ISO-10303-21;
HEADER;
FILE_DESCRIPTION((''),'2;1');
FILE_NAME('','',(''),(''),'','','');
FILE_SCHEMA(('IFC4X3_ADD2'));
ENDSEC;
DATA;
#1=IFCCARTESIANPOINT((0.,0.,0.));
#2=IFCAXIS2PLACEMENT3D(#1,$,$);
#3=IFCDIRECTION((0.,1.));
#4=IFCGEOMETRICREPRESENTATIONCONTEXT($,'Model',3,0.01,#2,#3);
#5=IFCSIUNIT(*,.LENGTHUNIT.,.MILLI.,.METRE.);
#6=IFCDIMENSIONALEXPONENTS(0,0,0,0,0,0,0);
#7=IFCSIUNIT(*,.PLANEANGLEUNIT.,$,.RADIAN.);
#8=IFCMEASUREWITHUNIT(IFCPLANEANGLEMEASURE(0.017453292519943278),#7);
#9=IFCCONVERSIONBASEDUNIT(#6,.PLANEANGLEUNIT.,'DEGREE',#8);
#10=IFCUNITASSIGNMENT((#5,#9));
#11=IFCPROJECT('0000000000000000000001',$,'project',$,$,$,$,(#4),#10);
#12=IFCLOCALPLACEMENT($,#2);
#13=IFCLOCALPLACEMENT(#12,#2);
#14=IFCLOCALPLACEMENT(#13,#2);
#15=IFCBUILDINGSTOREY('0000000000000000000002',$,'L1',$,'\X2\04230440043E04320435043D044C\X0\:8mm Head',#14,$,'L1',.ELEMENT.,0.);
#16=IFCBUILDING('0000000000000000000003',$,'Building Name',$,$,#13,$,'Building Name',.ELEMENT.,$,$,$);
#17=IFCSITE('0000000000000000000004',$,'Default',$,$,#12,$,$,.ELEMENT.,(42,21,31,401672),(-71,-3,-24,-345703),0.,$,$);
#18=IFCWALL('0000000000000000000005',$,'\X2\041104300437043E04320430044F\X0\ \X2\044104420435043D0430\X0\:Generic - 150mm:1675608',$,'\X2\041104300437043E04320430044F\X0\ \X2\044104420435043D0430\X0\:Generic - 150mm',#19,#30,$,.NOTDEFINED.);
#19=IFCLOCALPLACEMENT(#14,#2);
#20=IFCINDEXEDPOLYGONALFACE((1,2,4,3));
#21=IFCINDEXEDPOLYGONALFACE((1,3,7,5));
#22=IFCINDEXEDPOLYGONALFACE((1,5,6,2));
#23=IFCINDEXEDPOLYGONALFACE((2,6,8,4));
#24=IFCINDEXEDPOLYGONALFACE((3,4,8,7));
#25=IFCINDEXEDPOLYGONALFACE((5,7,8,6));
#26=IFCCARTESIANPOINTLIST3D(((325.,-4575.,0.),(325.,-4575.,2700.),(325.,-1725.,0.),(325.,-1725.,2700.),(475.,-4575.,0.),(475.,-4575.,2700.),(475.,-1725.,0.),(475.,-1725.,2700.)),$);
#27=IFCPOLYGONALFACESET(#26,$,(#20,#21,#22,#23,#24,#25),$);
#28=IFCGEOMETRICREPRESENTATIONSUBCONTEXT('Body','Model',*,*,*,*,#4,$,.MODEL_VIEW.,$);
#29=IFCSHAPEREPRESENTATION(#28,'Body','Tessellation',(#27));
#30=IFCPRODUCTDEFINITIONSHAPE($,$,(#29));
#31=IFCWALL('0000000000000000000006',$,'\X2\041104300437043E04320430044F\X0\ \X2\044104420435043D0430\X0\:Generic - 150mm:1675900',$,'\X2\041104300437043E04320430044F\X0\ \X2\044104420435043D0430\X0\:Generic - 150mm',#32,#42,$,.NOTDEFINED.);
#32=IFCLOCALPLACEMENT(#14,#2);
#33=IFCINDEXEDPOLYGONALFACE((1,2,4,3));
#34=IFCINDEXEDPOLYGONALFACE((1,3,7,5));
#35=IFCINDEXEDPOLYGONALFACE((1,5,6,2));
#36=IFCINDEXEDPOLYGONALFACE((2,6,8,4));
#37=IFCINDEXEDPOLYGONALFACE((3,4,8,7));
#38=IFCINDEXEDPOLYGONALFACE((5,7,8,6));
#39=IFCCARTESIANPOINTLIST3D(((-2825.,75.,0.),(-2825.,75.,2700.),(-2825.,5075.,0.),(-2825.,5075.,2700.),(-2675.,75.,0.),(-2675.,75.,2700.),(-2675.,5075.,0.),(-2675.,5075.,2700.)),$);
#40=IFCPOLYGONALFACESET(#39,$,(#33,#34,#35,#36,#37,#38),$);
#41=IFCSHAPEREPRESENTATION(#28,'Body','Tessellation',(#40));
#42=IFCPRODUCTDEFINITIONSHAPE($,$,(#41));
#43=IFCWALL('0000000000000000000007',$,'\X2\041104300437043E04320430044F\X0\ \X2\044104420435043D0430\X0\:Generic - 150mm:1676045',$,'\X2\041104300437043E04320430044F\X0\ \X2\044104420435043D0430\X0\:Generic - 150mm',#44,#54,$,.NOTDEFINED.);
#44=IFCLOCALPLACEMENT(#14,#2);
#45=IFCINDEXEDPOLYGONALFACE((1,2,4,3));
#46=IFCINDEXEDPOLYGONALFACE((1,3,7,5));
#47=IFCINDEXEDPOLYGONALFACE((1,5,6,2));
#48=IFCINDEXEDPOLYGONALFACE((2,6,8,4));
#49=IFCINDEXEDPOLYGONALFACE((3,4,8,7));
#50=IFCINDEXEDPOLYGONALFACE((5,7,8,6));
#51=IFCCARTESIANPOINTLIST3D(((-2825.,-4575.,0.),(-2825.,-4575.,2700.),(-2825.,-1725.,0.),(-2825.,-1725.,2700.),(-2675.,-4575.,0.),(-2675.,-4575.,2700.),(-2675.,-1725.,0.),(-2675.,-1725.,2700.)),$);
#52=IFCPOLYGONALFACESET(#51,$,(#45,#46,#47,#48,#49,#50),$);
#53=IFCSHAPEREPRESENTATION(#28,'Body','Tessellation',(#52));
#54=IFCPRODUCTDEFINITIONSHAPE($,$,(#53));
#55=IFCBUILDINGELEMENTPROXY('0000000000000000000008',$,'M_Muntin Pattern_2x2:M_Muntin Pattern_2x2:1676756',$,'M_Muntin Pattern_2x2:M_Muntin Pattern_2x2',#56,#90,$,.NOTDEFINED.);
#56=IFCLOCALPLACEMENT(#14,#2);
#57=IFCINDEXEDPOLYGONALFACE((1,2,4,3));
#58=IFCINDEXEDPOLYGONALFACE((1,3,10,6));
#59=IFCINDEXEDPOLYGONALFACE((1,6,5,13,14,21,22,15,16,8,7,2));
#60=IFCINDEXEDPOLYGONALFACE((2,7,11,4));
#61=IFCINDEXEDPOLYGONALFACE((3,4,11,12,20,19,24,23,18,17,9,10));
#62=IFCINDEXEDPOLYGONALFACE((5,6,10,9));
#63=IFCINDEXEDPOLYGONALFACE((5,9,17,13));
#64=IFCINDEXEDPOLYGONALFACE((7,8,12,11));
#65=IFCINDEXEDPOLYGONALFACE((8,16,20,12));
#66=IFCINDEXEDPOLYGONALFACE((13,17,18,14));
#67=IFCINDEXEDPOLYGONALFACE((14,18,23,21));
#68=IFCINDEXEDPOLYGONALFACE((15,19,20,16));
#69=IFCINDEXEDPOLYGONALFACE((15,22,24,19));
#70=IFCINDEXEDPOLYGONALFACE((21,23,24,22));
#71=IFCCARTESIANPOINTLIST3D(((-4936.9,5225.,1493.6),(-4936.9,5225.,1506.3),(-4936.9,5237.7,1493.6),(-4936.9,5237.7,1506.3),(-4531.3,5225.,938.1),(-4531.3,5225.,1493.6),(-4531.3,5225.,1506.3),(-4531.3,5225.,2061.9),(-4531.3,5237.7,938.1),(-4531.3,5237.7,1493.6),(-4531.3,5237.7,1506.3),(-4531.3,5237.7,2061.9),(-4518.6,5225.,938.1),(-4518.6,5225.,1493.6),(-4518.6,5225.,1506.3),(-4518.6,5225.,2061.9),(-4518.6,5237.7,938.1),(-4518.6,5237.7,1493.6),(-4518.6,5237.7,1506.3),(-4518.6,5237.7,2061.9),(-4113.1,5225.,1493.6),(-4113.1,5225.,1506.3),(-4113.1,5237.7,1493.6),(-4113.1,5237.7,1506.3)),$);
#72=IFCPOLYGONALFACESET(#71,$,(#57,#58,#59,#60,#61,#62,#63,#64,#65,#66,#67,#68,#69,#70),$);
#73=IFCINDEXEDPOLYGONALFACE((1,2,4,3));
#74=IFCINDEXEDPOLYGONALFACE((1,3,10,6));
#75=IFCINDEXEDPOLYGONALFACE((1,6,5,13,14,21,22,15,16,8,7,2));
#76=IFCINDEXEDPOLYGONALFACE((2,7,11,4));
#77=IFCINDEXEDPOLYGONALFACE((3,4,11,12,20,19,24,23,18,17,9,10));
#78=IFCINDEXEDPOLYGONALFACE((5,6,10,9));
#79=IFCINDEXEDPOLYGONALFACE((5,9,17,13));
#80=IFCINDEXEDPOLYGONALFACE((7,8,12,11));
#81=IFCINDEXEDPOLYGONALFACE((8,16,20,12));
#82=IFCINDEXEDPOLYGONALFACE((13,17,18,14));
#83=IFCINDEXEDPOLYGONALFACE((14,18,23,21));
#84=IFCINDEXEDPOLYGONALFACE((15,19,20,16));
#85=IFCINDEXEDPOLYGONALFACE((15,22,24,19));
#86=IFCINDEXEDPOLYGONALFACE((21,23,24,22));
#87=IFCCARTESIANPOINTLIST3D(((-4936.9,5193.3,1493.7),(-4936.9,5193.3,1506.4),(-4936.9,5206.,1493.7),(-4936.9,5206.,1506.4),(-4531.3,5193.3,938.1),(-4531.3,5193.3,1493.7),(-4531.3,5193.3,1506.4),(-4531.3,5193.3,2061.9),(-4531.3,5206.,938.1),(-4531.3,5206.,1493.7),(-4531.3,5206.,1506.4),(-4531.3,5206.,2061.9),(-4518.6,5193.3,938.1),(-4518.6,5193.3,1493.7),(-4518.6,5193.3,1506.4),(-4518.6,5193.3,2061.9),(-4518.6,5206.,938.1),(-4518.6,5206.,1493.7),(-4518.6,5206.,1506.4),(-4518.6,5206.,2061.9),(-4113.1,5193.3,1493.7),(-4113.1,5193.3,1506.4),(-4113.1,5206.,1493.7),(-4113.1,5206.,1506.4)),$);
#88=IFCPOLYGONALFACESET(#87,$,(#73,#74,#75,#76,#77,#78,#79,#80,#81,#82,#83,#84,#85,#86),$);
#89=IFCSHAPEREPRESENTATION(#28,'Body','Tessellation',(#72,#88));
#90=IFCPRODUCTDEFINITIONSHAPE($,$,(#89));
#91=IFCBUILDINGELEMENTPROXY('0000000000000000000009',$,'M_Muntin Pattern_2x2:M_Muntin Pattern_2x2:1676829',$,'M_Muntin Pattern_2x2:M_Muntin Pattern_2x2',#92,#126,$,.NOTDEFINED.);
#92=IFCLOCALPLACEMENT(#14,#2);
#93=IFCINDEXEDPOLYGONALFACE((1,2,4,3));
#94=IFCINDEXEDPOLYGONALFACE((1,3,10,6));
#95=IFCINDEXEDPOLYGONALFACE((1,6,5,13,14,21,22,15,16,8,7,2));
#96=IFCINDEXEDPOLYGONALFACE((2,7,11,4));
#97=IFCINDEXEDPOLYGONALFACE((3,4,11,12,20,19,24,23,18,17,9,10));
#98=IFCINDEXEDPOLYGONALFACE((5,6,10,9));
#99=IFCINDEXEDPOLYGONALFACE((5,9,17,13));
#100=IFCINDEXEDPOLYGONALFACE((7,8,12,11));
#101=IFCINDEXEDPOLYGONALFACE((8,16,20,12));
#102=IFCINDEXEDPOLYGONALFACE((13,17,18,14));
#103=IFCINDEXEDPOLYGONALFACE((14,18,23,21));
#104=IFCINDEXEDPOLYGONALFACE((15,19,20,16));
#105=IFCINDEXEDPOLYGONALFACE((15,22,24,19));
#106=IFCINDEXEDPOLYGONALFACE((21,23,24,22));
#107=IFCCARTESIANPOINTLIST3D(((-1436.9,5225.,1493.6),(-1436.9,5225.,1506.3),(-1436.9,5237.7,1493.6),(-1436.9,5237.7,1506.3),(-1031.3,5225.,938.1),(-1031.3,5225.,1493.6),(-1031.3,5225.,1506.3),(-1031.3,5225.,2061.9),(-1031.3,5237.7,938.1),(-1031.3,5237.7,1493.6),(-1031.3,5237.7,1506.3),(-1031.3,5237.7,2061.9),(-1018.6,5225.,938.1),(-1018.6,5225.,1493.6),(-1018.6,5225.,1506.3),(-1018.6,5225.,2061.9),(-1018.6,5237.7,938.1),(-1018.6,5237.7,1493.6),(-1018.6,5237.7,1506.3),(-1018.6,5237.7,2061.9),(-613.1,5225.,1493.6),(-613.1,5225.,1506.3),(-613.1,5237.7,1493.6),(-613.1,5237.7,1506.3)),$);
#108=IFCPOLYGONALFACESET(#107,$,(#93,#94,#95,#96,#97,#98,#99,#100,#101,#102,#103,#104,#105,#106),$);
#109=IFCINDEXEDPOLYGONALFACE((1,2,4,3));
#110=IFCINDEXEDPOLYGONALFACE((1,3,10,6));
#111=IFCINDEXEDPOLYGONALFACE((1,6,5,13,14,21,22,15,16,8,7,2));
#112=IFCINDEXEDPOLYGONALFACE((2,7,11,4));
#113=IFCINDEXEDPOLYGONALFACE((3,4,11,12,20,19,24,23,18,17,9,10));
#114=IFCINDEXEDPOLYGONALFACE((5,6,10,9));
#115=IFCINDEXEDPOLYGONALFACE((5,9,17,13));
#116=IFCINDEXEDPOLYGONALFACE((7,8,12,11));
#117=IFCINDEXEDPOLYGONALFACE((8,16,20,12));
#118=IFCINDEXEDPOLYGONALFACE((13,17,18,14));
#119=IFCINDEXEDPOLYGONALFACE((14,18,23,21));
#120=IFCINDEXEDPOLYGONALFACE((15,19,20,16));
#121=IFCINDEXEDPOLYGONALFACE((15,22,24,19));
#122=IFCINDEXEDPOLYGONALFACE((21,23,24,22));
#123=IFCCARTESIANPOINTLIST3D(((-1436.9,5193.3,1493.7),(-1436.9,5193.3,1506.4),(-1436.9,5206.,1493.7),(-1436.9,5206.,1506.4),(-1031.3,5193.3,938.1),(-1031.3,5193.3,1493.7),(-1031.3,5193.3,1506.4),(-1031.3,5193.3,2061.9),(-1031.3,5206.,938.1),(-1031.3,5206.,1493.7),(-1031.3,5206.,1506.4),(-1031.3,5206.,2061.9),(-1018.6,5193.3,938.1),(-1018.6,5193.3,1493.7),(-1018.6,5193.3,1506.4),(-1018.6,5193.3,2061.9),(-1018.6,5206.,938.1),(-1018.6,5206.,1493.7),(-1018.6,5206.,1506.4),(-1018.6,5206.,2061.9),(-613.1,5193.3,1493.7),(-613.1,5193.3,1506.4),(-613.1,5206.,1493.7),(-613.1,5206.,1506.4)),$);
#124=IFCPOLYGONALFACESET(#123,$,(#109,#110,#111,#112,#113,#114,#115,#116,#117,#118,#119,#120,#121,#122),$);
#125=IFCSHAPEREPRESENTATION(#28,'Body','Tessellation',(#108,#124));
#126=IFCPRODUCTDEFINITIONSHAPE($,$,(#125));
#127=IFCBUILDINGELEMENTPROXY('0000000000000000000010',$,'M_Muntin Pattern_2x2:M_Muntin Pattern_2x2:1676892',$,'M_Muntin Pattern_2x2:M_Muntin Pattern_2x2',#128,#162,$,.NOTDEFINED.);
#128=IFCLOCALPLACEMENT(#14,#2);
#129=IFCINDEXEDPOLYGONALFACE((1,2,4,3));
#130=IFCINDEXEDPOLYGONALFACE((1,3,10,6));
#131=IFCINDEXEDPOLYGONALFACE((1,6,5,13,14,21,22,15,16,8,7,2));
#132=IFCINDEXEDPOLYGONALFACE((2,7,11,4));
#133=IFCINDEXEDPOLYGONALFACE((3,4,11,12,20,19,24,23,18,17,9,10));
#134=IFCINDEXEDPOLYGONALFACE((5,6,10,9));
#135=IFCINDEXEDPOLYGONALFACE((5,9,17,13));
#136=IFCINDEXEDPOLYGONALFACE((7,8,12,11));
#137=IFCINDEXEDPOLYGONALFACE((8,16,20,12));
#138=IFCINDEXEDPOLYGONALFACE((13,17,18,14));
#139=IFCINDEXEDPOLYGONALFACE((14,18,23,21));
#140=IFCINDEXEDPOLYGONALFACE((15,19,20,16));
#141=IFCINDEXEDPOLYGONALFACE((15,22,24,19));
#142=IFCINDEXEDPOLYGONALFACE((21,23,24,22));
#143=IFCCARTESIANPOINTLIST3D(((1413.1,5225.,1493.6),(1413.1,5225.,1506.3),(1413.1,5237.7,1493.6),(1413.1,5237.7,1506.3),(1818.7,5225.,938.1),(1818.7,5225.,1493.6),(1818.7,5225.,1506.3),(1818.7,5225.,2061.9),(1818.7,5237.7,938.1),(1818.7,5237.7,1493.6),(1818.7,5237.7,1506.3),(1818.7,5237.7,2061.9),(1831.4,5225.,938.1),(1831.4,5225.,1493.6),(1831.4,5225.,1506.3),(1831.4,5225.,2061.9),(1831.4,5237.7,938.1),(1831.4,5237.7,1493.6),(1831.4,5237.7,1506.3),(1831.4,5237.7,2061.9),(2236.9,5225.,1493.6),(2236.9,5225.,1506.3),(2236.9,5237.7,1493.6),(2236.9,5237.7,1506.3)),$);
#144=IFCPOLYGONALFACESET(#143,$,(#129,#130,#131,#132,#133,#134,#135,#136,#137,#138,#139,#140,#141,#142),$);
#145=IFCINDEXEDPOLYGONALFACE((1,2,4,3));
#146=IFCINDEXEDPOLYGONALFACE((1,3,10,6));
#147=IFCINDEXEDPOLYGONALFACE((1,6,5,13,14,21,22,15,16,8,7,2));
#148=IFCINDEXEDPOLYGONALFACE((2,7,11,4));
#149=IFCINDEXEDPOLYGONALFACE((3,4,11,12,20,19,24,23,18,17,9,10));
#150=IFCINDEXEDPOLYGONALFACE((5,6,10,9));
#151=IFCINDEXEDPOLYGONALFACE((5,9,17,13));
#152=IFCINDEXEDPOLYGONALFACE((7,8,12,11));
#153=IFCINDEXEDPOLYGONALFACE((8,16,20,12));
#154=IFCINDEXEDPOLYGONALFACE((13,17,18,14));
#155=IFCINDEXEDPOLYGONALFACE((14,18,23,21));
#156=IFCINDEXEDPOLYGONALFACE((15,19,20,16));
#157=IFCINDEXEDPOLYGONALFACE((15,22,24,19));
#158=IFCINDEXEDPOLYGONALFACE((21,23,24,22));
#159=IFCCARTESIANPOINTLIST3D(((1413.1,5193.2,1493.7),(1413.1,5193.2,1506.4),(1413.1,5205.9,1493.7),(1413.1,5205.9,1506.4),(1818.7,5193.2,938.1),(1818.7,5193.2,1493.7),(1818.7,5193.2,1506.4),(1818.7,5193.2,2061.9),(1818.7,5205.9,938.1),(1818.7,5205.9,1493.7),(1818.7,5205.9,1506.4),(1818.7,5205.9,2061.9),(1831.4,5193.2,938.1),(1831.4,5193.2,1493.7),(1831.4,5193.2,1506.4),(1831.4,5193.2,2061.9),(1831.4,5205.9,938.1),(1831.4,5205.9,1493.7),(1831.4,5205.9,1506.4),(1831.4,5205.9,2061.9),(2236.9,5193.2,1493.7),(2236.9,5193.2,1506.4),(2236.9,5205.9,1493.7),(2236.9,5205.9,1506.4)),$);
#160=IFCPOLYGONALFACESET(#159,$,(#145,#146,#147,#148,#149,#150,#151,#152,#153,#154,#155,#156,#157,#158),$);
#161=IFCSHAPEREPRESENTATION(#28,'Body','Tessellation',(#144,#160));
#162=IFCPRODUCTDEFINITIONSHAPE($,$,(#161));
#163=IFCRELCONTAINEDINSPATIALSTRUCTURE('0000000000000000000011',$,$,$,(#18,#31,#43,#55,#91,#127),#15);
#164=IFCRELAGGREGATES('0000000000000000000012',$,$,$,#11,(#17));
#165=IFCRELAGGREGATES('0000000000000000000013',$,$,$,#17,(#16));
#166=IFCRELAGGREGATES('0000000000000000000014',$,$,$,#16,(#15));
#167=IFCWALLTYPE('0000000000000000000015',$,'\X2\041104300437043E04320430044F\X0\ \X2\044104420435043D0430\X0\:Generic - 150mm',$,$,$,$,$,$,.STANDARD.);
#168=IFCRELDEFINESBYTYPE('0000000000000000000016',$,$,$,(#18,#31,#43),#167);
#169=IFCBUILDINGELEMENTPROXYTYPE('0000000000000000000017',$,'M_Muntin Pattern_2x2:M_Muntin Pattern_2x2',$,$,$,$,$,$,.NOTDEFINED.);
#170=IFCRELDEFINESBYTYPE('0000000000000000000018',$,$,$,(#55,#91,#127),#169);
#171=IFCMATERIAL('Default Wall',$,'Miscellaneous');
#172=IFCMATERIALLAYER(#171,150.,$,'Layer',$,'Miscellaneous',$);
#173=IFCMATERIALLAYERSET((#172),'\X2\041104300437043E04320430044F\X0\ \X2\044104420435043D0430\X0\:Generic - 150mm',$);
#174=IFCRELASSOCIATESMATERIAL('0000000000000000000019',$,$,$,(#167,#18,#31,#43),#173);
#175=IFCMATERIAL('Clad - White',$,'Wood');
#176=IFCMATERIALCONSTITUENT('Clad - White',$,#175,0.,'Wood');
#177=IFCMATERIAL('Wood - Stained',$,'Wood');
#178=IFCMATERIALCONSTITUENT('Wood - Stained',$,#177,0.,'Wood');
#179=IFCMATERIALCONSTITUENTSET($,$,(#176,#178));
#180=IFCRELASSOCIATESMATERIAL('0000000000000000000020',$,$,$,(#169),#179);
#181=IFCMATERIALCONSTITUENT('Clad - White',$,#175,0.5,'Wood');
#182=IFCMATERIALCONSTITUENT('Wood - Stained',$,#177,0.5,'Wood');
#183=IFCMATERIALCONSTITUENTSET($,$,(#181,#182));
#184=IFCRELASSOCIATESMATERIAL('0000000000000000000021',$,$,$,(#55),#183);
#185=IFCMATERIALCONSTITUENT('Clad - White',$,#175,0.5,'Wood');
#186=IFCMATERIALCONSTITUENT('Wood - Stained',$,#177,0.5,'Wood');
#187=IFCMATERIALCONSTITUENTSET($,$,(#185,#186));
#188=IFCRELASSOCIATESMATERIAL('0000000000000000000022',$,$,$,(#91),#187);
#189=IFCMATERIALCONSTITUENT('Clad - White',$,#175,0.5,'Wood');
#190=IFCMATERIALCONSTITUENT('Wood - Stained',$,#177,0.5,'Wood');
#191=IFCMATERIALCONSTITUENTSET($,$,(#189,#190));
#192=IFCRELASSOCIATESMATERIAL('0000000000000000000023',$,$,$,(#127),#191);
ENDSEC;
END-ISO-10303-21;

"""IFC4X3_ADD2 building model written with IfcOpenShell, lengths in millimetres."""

from ifc_helpers import new_model, entity, si_unit, converted_unit, direction, frame, frame_2d, origin, place, context, subcontext, project, spatial, polyline, rectangle, outline, extrude, source, transform, mapped, material, layer, layer_set, constituent, constituent_set, type_object, type_shapes, element, save


model = new_model("IFC4X3_ADD2")

# Units and contexts
model_context = context("Model", 3, precision=0.01, world=origin(), true_north=direction((0.0, 1.0)))
body_context = subcontext(model_context, "Body", "Model", "MODEL_VIEW")
ifc_project = project(units=[si_unit("LENGTHUNIT", "METRE", prefix="MILLI"), converted_unit("PLANEANGLEUNIT", "DEGREE", entity("IfcPlaneAngleMeasure", 0.017453292519943278), si_unit("PLANEANGLEUNIT", "RADIAN"), dimensions=[0, 0, 0, 0, 0, 0, 0])], contexts=[model_context])

# Site, building, storey
site_placement = place(None, origin())
site = spatial("IfcSite", under=ifc_project, at=site_placement, Name="Default", CompositionType="ELEMENT", RefLatitude=(42, 21, 31, 401672), RefLongitude=(-71, -3, -24, -345703), RefElevation=0.0)
building_placement = place(site_placement, origin())
building = spatial("IfcBuilding", under=site, at=building_placement, Name="Building Name", LongName="Building Name", CompositionType="ELEMENT")
storey_placement = place(building_placement, origin())
storey = spatial("IfcBuildingStorey", under=building, at=storey_placement, Name="L1", ObjectType="Уровень:8mm Head", LongName="L1", CompositionType="ELEMENT", Elevation=0.0)

# Shared definitions
ifc_material_1 = material(Name="Default Wall", Category="Miscellaneous")
ifc_layer_1 = layer(ifc_material_1, 150.0, Name="Layer", Category="Miscellaneous")
ifc_layer_set_1 = layer_set([ifc_layer_1], Name="Базовая стена:Generic - 150mm")
wall_type = type_object("IfcWallType", Name="Базовая стена:Generic - 150mm", PredefinedType="STANDARD", material=ifc_layer_set_1)

# Walls
wall_1_placement = place(storey_placement, frame((400.0, -1725.0, 0.0), z_axis=(0.0, 0.0, 1.0), x_axis=(0.0, -1.0, 0.0)))
element("IfcWall", 1, at=wall_1_placement, inside=storey, type_object=wall_type, material=ifc_layer_set_1, Name="Базовая стена:Generic - 150mm:1675608", ObjectType="Базовая стена:Generic - 150mm", PredefinedType="NOTDEFINED", context=body_context, shape_type="SweptSolid", body=[
    extrude(rectangle(XDim=2850.0, YDim=150.0, at=frame_2d((1425.0, 0.0), x_axis=(-1.0, 0.0))), origin(), (0.0, 0.0, 1.0), 2700.0),
])
wall_2_placement = place(storey_placement, frame((-2750.0, 75.0, 0.0), z_axis=(0.0, 0.0, 1.0), x_axis=(0.0, 1.0, 0.0)))
element("IfcWall", 2, at=wall_2_placement, inside=storey, type_object=wall_type, material=ifc_layer_set_1, Name="Базовая стена:Generic - 150mm:1675900", ObjectType="Базовая стена:Generic - 150mm", PredefinedType="NOTDEFINED", context=body_context, shape_type="SweptSolid", body=[
    extrude(rectangle(XDim=5000.0, YDim=150.0, at=frame_2d((2500.0, 0.0), x_axis=(-1.0, 0.0))), origin(), (0.0, 0.0, 1.0), 2700.0),
])
wall_3_placement = place(storey_placement, frame((-2750.0, -1725.0, 0.0), z_axis=(0.0, 0.0, 1.0), x_axis=(0.0, -1.0, 0.0)))
element("IfcWall", 3, at=wall_3_placement, inside=storey, type_object=wall_type, material=ifc_layer_set_1, Name="Базовая стена:Generic - 150mm:1676045", ObjectType="Базовая стена:Generic - 150mm", PredefinedType="NOTDEFINED", context=body_context, shape_type="SweptSolid", body=[
    extrude(rectangle(XDim=2850.0, YDim=150.0, at=frame_2d((1425.0, 0.0), x_axis=(-1.0, 0.0))), origin(), (0.0, 0.0, 1.0), 2700.0),
])

# Building element proxies
ifc_material_2 = material(Name="Clad - White", Category="Wood")
ifc_constituent_1 = constituent(ifc_material_2, Name="Clad - White", Category="Wood", fraction=0.5)
ifc_material_3 = material(Name="Wood - Stained", Category="Wood")
ifc_constituent_2 = constituent(ifc_material_3, Name="Wood - Stained", Category="Wood", fraction=0.5)
ifc_constituent_set_1 = constituent_set(constituents=[ifc_constituent_1, ifc_constituent_2])
ifc_constituent_3 = constituent(ifc_material_2, Name="Clad - White", Category="Wood", fraction=0.0)
ifc_constituent_4 = constituent(ifc_material_3, Name="Wood - Stained", Category="Wood", fraction=0.0)
ifc_constituent_set_2 = constituent_set(constituents=[ifc_constituent_3, ifc_constituent_4])
building_element_proxy_type_1 = type_object("IfcBuildingElementProxyType", Name="M_Muntin Pattern_2x2:M_Muntin Pattern_2x2", PredefinedType="NOTDEFINED", material=ifc_constituent_set_2)
shared_shape_1 = source(origin(), body_context, "Body", "SweptSolid", [
    extrude(outline(polyline([(6.4, -6.4), (561.9, -6.4), (561.9, 6.3), (6.4, 6.3), (6.4, 411.9), (-6.3, 411.9), (-6.3, 6.3), (-561.9, 6.3), (-561.9, -6.4), (-6.3, -6.4), (-6.3, -411.9), (6.4, -411.9), (6.4, -6.4)])), frame((0.0, -22.2, 561.9), z_axis=(0.0, 1.0, 0.0), x_axis=(0.0, 0.0, 1.0)), (0.0, 0.0, 1.0), 12.7),
    extrude(outline(polyline([(6.4, -6.4), (561.9, -6.4), (561.9, 6.3), (6.4, 6.3), (6.4, 411.9), (-6.3, 411.9), (-6.3, 6.3), (-561.9, 6.3), (-561.9, -6.4), (-6.3, -6.4), (-6.3, -411.9), (6.4, -411.9), (6.4, -6.4)])), frame((0.0, 9.5, 561.9), z_axis=(0.0, 1.0, 0.0), x_axis=(0.0, 0.0, 1.0)), (0.0, 0.0, 1.0), 12.7),
])
type_shapes(building_element_proxy_type_1, [shared_shape_1])
proxy_1_placement = place(storey_placement, frame((-4525.0, 5215.5, 938.1), z_axis=(0.0, 0.0, 1.0), x_axis=(-1.0, 0.0, 0.0)))
element("IfcBuildingElementProxy", 4, at=proxy_1_placement, inside=storey, type_object=building_element_proxy_type_1, material=ifc_constituent_set_1, Name="M_Muntin Pattern_2x2:M_Muntin Pattern_2x2:1676756", ObjectType="M_Muntin Pattern_2x2:M_Muntin Pattern_2x2", PredefinedType="NOTDEFINED", context=body_context, shape_type="MappedRepresentation", body=[
    mapped(shared_shape_1, transform((0.0, 0.0, 0.0), scale=1.0)),
])
ifc_constituent_5 = constituent(ifc_material_2, Name="Clad - White", Category="Wood", fraction=0.5)
ifc_constituent_6 = constituent(ifc_material_3, Name="Wood - Stained", Category="Wood", fraction=0.5)
ifc_constituent_set_3 = constituent_set(constituents=[ifc_constituent_5, ifc_constituent_6])
proxy_2_placement = place(storey_placement, frame((-1025.0, 5215.5, 938.1), z_axis=(0.0, 0.0, 1.0), x_axis=(-1.0, 0.0, 0.0)))
element("IfcBuildingElementProxy", 5, at=proxy_2_placement, inside=storey, type_object=building_element_proxy_type_1, material=ifc_constituent_set_3, Name="M_Muntin Pattern_2x2:M_Muntin Pattern_2x2:1676829", ObjectType="M_Muntin Pattern_2x2:M_Muntin Pattern_2x2", PredefinedType="NOTDEFINED", context=body_context, shape_type="MappedRepresentation", body=[
    mapped(shared_shape_1, transform((0.0, 0.0, 0.0), scale=1.0)),
])
ifc_constituent_7 = constituent(ifc_material_2, Name="Clad - White", Category="Wood", fraction=0.5)
ifc_constituent_8 = constituent(ifc_material_3, Name="Wood - Stained", Category="Wood", fraction=0.5)
ifc_constituent_set_4 = constituent_set(constituents=[ifc_constituent_7, ifc_constituent_8])
proxy_3_placement = place(storey_placement, frame((1825.0, 5215.5, 938.1), z_axis=(0.0, 0.0, 1.0), x_axis=(-1.0, 0.0, 0.0)))
element("IfcBuildingElementProxy", 6, at=proxy_3_placement, inside=storey, type_object=building_element_proxy_type_1, material=ifc_constituent_set_4, Name="M_Muntin Pattern_2x2:M_Muntin Pattern_2x2:1676892", ObjectType="M_Muntin Pattern_2x2:M_Muntin Pattern_2x2", PredefinedType="NOTDEFINED", context=body_context, shape_type="MappedRepresentation", body=[
    mapped(shared_shape_1, transform((0.0, 0.0, 0.0), scale=1.0)),
])

save(model, "model.ifc")
